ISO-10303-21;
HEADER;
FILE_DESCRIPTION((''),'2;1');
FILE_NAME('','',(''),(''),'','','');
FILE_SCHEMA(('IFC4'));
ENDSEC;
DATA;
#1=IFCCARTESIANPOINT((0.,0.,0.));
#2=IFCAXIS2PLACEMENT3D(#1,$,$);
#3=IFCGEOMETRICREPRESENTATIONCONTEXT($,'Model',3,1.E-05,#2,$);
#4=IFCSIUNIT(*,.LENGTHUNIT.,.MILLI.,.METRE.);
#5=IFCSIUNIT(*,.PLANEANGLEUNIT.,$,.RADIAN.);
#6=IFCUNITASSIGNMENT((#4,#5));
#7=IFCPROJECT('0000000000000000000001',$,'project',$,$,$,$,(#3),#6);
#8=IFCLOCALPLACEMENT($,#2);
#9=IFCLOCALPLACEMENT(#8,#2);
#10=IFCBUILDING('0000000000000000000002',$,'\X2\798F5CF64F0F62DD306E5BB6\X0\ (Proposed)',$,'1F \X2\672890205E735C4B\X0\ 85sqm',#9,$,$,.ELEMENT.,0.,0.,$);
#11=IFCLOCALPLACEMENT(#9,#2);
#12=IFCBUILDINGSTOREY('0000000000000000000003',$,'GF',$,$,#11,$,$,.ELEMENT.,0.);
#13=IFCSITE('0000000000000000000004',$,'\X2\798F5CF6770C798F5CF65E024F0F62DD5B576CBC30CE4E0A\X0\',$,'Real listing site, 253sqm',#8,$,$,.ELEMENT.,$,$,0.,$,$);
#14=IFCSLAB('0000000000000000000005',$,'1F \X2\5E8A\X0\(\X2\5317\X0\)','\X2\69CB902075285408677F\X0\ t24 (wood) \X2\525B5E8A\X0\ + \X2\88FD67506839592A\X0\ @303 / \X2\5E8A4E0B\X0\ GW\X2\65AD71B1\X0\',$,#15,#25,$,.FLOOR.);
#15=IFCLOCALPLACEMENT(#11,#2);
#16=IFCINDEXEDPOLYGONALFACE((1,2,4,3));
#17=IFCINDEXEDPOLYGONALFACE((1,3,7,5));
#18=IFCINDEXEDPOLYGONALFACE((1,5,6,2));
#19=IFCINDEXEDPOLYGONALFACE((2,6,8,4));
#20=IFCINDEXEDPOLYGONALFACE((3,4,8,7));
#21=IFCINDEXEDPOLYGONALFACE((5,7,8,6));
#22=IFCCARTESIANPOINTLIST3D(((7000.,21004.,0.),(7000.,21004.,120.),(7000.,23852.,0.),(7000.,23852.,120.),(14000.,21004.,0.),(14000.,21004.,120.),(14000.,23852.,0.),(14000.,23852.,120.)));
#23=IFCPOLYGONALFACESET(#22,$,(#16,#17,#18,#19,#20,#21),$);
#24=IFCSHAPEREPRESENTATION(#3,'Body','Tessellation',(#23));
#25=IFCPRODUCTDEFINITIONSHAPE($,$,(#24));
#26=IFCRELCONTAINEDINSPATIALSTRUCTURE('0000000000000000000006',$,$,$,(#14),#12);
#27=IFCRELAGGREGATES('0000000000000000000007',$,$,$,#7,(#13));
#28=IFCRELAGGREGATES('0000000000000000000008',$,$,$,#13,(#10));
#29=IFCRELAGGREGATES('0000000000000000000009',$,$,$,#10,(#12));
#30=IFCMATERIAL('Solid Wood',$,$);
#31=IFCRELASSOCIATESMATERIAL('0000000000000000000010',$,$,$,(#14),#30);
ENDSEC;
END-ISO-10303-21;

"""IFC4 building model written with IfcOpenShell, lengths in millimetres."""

from ifc_helpers import new_model, si_unit, frame, frame_2d, origin, place, context, project, spatial, rectangle, extrude, material, element, save


model = new_model("IFC4")

# Units and contexts
model_context = context("Model", 3, precision=1e-05, world=origin())
ifc_project = project(units=[si_unit("LENGTHUNIT", "METRE", prefix="MILLI"), si_unit("PLANEANGLEUNIT", "RADIAN")], contexts=[model_context])

# Site, building, storey
site_placement = place(None, origin())
site = spatial("IfcSite", under=ifc_project, at=site_placement, Name="福島県福島市伏拝字沼ノ上", ObjectType="Real listing site, 253sqm", CompositionType="ELEMENT", RefElevation=0.0)
building_placement = place(site_placement, origin())
building = spatial("IfcBuilding", under=site, at=building_placement, Name="福島伏拝の家 (Proposed)", ObjectType="1F 木造平屋 85sqm", CompositionType="ELEMENT", ElevationOfRefHeight=0.0, ElevationOfTerrain=0.0)
storey_placement = place(building_placement, origin())
storey = spatial("IfcBuildingStorey", under=building, at=storey_placement, Name="GF", CompositionType="ELEMENT", Elevation=0.0)

# Slab
ifc_material_1 = material(Name="Solid Wood")
slab_1_placement = place(storey_placement, frame((3500.0, 10502.0, 0.0)))
element("IfcSlab", 1, at=slab_1_placement, inside=storey, material=ifc_material_1, Name="1F 床(北)", Description="構造用合板 t24 (wood) 剛床 + 製材根太 @303 / 床下 GW断熱", PredefinedType="FLOOR", context=model_context, shape_type="SweptSolid", body=[
    extrude(rectangle(XDim=7000.0, YDim=2848.0, at=frame_2d((3500.0, 1424.0))), frame((3500.0, 10502.0, 0.0)), (0.0, 0.0, 1.0), 120.0),
])

save(model, "model.ifc")
